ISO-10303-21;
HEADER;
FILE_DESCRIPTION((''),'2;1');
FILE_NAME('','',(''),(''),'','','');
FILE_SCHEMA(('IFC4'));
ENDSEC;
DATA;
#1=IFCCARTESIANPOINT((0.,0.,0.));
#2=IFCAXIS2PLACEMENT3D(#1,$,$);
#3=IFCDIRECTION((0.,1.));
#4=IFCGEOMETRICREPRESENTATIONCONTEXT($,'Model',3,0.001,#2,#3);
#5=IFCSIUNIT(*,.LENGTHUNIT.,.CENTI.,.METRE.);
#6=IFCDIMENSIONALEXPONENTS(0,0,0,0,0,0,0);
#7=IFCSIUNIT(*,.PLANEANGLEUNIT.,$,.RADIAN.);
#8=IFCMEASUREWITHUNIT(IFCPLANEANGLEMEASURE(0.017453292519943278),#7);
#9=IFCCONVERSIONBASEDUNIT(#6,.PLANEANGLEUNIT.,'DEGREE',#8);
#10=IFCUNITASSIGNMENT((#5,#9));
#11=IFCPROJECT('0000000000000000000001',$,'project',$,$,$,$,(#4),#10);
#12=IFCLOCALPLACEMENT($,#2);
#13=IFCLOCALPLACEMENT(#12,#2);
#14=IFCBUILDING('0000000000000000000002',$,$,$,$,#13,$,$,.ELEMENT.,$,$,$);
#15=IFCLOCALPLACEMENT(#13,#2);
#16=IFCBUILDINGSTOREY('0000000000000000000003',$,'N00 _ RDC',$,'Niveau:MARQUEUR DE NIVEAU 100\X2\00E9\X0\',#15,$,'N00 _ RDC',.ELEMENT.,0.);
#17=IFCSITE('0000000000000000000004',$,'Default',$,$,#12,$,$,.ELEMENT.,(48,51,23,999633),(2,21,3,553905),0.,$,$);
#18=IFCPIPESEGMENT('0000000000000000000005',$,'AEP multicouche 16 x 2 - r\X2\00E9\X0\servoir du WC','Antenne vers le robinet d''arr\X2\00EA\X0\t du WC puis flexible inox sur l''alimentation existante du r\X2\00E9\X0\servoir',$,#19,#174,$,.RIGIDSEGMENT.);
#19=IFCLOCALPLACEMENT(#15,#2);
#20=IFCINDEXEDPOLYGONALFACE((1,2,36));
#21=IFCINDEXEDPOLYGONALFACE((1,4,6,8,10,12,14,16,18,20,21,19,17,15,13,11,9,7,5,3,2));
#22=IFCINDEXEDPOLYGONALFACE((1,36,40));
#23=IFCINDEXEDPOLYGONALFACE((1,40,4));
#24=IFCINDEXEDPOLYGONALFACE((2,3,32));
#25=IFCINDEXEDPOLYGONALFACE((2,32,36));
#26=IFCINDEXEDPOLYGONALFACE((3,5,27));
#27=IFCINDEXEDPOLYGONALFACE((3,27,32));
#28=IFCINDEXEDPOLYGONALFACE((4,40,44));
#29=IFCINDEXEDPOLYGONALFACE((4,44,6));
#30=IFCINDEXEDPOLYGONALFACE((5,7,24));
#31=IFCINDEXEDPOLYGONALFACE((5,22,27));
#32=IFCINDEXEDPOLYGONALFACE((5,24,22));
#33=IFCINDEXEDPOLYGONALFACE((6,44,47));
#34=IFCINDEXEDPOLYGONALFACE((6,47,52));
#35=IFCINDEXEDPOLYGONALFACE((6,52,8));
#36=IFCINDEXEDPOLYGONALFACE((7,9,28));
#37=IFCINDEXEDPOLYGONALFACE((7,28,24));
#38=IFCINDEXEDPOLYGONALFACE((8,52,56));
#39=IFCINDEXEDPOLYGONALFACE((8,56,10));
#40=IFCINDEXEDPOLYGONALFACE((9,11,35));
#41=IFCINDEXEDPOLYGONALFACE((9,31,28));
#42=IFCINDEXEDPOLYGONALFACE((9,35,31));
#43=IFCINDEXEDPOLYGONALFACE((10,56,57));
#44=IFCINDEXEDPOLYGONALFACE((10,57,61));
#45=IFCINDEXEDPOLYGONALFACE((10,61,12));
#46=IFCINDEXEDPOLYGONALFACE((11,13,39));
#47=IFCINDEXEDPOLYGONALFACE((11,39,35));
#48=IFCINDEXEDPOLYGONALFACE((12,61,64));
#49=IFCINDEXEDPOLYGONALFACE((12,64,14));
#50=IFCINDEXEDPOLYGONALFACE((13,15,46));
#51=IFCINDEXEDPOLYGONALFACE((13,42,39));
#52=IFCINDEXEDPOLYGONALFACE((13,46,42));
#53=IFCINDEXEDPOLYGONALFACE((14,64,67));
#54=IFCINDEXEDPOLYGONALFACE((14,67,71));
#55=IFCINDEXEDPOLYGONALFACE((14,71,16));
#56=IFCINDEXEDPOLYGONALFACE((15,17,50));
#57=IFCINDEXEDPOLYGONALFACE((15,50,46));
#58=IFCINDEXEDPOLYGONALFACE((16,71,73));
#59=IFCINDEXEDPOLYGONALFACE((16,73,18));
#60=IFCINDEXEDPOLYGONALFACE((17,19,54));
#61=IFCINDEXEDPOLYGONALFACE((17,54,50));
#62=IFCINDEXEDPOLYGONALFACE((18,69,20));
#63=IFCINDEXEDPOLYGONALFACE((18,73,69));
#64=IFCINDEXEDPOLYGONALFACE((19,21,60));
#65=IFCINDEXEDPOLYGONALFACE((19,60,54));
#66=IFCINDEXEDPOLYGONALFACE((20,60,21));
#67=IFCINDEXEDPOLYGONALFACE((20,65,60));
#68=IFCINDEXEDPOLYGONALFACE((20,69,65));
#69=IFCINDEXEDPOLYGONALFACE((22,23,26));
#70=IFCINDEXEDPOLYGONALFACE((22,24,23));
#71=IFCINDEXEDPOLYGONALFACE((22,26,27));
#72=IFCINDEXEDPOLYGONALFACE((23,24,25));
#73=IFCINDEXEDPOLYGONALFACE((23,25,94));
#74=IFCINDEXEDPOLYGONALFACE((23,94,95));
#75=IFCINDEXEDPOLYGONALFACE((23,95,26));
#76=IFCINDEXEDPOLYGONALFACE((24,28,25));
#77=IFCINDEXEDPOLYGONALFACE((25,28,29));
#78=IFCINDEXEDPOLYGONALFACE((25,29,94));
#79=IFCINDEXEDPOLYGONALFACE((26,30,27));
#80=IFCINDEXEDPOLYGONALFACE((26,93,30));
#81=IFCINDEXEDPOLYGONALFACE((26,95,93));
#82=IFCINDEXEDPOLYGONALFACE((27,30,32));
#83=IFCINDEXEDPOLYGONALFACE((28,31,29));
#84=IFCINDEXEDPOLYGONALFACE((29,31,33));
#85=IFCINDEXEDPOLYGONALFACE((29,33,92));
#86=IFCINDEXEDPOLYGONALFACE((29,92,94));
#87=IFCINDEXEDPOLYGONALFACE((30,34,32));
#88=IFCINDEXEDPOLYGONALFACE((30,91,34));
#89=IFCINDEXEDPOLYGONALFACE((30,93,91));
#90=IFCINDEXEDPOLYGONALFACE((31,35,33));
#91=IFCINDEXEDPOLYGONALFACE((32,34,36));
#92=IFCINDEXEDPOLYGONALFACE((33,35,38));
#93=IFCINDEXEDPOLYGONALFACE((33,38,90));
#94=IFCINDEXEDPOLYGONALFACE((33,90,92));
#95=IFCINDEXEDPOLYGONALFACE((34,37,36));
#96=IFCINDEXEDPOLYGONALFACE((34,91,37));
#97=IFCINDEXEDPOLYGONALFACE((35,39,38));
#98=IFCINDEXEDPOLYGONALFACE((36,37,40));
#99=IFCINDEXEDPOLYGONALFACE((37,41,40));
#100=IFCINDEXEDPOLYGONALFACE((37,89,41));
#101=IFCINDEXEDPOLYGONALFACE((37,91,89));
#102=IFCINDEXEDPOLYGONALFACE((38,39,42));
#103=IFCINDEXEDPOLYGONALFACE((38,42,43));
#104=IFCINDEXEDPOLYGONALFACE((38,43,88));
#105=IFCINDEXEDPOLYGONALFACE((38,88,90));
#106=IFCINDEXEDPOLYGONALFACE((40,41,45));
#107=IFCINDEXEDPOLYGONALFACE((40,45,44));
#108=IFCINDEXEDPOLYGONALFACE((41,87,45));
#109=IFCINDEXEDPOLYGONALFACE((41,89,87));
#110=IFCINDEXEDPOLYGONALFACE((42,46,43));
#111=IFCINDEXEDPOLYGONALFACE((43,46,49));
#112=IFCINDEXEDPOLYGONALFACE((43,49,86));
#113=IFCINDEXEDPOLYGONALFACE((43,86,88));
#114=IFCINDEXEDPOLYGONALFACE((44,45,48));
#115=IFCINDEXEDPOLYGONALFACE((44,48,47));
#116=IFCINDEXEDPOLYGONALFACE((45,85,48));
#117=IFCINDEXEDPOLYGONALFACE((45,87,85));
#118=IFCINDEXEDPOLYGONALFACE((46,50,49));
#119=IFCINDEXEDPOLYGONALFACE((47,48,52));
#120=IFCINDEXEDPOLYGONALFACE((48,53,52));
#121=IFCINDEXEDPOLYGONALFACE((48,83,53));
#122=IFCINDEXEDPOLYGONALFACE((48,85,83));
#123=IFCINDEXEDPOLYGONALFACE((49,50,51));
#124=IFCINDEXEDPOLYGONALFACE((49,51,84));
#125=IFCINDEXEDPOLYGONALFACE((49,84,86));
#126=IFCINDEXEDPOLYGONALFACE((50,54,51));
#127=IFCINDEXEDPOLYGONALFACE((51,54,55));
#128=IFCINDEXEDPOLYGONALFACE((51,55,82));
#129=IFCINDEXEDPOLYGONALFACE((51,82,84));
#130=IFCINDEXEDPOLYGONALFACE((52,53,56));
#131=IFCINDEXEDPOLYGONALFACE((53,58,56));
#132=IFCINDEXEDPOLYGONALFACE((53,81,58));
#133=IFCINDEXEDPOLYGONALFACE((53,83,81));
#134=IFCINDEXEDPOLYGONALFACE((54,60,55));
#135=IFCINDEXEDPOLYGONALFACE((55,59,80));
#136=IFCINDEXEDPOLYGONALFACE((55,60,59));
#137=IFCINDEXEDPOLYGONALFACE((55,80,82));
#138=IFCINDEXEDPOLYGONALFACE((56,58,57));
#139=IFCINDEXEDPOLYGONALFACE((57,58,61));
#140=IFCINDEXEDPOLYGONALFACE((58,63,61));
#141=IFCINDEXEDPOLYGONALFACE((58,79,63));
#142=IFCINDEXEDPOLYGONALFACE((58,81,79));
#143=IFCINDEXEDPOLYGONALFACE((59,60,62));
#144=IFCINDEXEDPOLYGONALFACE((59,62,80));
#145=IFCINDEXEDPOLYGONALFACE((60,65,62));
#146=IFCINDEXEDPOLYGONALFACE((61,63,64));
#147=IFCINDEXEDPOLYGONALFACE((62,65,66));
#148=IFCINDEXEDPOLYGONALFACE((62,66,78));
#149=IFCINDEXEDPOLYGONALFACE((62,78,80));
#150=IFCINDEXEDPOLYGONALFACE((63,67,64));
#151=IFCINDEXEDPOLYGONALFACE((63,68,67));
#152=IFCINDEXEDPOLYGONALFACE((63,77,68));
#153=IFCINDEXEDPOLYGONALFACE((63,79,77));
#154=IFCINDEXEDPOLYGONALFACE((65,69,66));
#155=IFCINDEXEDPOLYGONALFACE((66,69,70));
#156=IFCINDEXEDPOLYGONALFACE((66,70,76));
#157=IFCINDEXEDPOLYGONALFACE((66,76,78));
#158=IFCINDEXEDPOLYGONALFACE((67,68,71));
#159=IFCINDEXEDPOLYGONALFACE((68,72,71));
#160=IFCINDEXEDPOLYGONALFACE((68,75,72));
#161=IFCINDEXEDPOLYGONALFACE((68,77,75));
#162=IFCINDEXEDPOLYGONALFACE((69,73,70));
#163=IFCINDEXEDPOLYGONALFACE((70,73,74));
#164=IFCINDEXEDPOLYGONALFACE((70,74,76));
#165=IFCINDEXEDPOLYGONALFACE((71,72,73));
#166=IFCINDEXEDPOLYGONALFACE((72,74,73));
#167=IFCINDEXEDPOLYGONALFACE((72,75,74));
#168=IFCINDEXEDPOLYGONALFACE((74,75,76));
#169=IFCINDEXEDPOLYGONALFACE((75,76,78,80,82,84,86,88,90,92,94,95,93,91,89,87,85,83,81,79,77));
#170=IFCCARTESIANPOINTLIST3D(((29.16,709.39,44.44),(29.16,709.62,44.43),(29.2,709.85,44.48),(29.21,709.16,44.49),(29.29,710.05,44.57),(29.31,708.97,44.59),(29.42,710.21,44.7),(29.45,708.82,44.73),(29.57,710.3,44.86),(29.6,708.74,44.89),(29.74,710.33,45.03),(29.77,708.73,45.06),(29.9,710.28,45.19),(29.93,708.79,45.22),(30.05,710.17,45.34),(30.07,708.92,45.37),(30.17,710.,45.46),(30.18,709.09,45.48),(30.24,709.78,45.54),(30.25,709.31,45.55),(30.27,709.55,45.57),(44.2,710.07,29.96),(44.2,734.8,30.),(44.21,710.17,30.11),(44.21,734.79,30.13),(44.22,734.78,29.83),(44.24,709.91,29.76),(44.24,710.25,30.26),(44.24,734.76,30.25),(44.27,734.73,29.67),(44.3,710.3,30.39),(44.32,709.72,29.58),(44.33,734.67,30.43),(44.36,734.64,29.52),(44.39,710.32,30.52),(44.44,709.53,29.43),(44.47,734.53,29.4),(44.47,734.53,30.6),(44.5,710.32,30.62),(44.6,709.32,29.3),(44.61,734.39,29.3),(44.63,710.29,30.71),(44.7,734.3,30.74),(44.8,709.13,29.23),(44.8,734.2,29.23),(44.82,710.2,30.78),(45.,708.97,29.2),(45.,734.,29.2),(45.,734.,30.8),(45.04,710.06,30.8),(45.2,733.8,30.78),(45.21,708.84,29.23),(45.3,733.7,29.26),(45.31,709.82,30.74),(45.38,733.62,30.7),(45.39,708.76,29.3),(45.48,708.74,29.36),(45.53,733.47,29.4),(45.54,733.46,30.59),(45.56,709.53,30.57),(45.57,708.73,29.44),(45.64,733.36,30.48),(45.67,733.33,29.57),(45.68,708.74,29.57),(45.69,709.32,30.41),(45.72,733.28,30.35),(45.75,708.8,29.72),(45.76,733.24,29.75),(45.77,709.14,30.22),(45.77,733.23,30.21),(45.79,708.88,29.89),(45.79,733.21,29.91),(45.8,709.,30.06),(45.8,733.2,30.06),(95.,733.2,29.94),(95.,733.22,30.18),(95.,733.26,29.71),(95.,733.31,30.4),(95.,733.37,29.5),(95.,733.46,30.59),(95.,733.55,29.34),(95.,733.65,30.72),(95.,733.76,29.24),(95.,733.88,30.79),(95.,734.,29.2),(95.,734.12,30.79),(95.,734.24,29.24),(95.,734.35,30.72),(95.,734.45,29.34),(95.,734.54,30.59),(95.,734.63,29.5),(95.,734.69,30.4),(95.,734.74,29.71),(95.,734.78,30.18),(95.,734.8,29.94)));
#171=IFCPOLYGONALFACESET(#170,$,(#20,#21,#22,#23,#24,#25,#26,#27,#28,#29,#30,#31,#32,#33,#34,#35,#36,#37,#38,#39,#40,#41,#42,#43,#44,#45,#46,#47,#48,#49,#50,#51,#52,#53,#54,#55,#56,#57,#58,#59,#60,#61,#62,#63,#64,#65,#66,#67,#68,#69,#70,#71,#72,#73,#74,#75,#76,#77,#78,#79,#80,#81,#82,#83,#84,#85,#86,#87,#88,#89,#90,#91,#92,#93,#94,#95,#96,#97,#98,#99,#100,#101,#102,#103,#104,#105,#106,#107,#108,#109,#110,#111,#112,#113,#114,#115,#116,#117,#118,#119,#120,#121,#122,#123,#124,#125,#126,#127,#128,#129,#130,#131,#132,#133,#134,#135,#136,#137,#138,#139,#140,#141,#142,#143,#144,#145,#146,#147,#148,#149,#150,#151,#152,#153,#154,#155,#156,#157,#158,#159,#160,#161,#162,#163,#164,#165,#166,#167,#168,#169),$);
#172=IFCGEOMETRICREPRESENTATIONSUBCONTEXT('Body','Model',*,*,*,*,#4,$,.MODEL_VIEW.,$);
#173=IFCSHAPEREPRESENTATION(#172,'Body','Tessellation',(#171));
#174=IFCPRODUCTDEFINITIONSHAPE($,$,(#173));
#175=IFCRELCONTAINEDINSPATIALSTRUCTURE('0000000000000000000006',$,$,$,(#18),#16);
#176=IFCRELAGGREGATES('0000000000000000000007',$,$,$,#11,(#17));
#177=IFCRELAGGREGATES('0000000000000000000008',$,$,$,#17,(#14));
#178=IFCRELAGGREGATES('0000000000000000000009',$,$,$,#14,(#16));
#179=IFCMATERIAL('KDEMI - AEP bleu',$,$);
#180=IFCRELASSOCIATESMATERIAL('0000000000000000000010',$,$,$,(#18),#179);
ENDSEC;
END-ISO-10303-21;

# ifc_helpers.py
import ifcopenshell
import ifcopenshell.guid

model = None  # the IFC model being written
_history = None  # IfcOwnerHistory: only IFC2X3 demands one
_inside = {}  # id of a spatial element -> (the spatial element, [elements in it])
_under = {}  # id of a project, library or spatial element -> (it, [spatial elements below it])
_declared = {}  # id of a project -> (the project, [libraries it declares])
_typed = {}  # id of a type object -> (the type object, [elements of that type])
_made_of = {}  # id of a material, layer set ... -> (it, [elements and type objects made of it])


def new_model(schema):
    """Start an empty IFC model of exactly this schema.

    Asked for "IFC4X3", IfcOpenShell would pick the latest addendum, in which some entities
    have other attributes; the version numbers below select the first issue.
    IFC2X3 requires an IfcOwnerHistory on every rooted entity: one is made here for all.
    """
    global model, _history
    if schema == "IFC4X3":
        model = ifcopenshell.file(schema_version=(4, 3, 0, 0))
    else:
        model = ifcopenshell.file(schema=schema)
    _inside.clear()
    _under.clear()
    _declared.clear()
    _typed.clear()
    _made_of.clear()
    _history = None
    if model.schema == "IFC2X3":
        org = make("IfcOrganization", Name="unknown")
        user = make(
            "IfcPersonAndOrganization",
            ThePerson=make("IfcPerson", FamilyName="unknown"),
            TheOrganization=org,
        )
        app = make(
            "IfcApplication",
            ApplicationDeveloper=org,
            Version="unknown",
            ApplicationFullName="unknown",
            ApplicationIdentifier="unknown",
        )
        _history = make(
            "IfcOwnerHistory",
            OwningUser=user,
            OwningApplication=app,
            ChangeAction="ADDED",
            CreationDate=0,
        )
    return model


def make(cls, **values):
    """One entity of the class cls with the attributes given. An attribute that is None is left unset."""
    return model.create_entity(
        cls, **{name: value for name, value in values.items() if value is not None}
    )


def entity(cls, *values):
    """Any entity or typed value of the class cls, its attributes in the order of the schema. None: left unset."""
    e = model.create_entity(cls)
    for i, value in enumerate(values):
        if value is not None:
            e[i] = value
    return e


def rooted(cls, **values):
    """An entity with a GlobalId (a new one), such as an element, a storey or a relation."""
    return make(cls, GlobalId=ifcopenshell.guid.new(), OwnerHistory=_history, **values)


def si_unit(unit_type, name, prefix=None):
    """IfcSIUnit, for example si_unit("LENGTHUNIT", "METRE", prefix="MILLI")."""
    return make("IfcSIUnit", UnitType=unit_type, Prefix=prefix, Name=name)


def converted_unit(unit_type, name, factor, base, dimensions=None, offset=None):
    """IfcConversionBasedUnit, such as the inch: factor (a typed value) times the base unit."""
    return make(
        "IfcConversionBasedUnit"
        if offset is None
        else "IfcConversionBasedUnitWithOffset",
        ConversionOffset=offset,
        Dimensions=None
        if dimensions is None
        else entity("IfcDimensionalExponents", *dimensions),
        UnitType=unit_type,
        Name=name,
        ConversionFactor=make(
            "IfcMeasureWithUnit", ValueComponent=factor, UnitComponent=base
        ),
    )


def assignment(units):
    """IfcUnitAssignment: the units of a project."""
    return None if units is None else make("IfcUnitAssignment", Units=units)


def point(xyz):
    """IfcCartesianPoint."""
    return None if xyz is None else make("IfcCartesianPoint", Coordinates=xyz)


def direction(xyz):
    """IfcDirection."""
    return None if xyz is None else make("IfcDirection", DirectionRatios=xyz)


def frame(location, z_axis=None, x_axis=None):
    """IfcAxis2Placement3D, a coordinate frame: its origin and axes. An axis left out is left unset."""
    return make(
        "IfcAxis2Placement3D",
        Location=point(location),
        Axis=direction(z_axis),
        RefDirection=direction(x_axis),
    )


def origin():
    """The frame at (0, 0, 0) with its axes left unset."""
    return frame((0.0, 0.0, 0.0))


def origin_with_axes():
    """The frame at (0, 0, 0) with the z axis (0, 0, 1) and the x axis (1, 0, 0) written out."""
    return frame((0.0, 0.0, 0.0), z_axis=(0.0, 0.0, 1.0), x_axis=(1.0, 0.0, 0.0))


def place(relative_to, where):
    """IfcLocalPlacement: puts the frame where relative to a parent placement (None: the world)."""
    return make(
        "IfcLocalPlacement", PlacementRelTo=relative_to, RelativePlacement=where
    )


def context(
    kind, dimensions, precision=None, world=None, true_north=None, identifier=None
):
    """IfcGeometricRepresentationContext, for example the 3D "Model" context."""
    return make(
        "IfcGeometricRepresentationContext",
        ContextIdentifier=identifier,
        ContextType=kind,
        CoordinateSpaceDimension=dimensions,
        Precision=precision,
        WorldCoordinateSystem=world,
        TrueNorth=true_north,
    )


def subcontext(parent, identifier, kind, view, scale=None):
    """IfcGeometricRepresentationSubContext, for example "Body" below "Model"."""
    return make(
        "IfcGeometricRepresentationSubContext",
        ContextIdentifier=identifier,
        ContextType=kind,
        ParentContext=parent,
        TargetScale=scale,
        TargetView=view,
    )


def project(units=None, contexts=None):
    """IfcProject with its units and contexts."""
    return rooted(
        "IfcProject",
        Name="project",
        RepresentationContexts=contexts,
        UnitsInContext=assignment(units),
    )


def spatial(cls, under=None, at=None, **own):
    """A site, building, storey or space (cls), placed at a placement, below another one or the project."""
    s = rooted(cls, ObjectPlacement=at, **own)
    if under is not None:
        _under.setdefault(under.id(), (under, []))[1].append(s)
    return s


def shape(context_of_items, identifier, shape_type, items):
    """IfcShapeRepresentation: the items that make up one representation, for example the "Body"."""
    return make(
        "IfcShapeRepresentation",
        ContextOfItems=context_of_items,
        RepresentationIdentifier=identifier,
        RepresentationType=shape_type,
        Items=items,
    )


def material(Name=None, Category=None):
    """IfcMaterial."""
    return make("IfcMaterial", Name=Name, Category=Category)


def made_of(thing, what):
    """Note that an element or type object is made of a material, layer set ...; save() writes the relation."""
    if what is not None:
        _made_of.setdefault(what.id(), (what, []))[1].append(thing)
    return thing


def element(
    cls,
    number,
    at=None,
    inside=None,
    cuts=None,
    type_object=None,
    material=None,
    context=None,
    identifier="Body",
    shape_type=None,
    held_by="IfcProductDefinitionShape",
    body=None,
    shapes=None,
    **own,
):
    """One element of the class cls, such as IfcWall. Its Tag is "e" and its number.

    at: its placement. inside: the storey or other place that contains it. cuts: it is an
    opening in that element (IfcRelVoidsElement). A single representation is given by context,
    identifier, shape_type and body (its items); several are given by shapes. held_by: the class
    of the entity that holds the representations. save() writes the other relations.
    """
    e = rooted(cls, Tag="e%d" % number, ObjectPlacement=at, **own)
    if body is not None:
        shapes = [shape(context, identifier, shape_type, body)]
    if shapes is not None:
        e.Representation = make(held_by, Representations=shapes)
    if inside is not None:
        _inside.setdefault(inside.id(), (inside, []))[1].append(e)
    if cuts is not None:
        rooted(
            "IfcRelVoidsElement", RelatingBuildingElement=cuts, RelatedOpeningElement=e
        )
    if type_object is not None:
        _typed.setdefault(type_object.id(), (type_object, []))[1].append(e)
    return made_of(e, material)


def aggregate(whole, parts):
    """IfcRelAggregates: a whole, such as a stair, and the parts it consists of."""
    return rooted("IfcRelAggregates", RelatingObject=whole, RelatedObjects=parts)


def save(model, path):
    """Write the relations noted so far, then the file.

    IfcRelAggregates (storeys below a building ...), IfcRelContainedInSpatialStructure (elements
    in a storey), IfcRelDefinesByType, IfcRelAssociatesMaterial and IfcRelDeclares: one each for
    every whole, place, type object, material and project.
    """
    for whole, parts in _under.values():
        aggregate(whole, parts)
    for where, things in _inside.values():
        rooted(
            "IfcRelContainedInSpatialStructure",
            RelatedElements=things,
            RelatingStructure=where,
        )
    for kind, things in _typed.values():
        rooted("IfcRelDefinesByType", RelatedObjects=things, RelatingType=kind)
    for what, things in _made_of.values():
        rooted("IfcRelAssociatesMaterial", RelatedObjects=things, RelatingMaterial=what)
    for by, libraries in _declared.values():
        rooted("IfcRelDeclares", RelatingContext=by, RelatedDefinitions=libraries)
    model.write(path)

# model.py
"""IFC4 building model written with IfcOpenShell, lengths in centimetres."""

from ifc_helpers import new_model, entity, si_unit, converted_unit, direction, origin, origin_with_axes, place, context, subcontext, project, spatial, material, element, save


model = new_model("IFC4")

# Units and contexts
model_context = context("Model", 3, precision=0.001, world=origin(), true_north=direction((0.0, 1.0)))
body_context = subcontext(model_context, "Body", "Model", "MODEL_VIEW")
ifc_project = project(units=[si_unit("LENGTHUNIT", "METRE", prefix="CENTI"), converted_unit("PLANEANGLEUNIT", "DEGREE", entity("IfcPlaneAngleMeasure", 0.017453292519943278), si_unit("PLANEANGLEUNIT", "RADIAN"), dimensions=[0, 0, 0, 0, 0, 0, 0])], contexts=[model_context])

# Site, building, storey
site_placement = place(None, origin())
site = spatial("IfcSite", under=ifc_project, at=site_placement, Name="Default", CompositionType="ELEMENT", RefLatitude=(48, 51, 23, 999633), RefLongitude=(2, 21, 3, 553905), RefElevation=0.0)
building_placement = place(site_placement, origin())
building = spatial("IfcBuilding", under=site, at=building_placement, CompositionType="ELEMENT")
storey_placement = place(building_placement, origin())
storey = spatial("IfcBuildingStorey", under=building, at=storey_placement, Name="N00 _ RDC", ObjectType="Niveau:MARQUEUR DE NIVEAU 100é", LongName="N00 _ RDC", CompositionType="ELEMENT", Elevation=0.0)

# Pipe segment
ifc_material_1 = material(Name="KDEMI - AEP bleu")
pipe_segment_1_placement = place(storey_placement, origin_with_axes())
element("IfcPipeSegment", 1, at=pipe_segment_1_placement, inside=storey, material=ifc_material_1, Name="AEP multicouche 16 x 2 - réservoir du WC", Description="Antenne vers le robinet d'arrêt du WC puis flexible inox sur l'alimentation existante du réservoir", PredefinedType="RIGIDSEGMENT", context=body_context, shape_type="AdvancedSweptSolid", body=[
    entity("IfcSweptDiskSolid", entity("IfcPolyline", [entity("IfcCartesianPoint", [95.0, 734.0, 30.0]), entity("IfcCartesianPoint", [45.0, 734.0, 30.0]), entity("IfcCartesianPoint", [45.0, 709.53, 30.0]), entity("IfcCartesianPoint", [29.71, 709.53, 45.0])]), 0.8),
])

save(model, "model.ifc")
